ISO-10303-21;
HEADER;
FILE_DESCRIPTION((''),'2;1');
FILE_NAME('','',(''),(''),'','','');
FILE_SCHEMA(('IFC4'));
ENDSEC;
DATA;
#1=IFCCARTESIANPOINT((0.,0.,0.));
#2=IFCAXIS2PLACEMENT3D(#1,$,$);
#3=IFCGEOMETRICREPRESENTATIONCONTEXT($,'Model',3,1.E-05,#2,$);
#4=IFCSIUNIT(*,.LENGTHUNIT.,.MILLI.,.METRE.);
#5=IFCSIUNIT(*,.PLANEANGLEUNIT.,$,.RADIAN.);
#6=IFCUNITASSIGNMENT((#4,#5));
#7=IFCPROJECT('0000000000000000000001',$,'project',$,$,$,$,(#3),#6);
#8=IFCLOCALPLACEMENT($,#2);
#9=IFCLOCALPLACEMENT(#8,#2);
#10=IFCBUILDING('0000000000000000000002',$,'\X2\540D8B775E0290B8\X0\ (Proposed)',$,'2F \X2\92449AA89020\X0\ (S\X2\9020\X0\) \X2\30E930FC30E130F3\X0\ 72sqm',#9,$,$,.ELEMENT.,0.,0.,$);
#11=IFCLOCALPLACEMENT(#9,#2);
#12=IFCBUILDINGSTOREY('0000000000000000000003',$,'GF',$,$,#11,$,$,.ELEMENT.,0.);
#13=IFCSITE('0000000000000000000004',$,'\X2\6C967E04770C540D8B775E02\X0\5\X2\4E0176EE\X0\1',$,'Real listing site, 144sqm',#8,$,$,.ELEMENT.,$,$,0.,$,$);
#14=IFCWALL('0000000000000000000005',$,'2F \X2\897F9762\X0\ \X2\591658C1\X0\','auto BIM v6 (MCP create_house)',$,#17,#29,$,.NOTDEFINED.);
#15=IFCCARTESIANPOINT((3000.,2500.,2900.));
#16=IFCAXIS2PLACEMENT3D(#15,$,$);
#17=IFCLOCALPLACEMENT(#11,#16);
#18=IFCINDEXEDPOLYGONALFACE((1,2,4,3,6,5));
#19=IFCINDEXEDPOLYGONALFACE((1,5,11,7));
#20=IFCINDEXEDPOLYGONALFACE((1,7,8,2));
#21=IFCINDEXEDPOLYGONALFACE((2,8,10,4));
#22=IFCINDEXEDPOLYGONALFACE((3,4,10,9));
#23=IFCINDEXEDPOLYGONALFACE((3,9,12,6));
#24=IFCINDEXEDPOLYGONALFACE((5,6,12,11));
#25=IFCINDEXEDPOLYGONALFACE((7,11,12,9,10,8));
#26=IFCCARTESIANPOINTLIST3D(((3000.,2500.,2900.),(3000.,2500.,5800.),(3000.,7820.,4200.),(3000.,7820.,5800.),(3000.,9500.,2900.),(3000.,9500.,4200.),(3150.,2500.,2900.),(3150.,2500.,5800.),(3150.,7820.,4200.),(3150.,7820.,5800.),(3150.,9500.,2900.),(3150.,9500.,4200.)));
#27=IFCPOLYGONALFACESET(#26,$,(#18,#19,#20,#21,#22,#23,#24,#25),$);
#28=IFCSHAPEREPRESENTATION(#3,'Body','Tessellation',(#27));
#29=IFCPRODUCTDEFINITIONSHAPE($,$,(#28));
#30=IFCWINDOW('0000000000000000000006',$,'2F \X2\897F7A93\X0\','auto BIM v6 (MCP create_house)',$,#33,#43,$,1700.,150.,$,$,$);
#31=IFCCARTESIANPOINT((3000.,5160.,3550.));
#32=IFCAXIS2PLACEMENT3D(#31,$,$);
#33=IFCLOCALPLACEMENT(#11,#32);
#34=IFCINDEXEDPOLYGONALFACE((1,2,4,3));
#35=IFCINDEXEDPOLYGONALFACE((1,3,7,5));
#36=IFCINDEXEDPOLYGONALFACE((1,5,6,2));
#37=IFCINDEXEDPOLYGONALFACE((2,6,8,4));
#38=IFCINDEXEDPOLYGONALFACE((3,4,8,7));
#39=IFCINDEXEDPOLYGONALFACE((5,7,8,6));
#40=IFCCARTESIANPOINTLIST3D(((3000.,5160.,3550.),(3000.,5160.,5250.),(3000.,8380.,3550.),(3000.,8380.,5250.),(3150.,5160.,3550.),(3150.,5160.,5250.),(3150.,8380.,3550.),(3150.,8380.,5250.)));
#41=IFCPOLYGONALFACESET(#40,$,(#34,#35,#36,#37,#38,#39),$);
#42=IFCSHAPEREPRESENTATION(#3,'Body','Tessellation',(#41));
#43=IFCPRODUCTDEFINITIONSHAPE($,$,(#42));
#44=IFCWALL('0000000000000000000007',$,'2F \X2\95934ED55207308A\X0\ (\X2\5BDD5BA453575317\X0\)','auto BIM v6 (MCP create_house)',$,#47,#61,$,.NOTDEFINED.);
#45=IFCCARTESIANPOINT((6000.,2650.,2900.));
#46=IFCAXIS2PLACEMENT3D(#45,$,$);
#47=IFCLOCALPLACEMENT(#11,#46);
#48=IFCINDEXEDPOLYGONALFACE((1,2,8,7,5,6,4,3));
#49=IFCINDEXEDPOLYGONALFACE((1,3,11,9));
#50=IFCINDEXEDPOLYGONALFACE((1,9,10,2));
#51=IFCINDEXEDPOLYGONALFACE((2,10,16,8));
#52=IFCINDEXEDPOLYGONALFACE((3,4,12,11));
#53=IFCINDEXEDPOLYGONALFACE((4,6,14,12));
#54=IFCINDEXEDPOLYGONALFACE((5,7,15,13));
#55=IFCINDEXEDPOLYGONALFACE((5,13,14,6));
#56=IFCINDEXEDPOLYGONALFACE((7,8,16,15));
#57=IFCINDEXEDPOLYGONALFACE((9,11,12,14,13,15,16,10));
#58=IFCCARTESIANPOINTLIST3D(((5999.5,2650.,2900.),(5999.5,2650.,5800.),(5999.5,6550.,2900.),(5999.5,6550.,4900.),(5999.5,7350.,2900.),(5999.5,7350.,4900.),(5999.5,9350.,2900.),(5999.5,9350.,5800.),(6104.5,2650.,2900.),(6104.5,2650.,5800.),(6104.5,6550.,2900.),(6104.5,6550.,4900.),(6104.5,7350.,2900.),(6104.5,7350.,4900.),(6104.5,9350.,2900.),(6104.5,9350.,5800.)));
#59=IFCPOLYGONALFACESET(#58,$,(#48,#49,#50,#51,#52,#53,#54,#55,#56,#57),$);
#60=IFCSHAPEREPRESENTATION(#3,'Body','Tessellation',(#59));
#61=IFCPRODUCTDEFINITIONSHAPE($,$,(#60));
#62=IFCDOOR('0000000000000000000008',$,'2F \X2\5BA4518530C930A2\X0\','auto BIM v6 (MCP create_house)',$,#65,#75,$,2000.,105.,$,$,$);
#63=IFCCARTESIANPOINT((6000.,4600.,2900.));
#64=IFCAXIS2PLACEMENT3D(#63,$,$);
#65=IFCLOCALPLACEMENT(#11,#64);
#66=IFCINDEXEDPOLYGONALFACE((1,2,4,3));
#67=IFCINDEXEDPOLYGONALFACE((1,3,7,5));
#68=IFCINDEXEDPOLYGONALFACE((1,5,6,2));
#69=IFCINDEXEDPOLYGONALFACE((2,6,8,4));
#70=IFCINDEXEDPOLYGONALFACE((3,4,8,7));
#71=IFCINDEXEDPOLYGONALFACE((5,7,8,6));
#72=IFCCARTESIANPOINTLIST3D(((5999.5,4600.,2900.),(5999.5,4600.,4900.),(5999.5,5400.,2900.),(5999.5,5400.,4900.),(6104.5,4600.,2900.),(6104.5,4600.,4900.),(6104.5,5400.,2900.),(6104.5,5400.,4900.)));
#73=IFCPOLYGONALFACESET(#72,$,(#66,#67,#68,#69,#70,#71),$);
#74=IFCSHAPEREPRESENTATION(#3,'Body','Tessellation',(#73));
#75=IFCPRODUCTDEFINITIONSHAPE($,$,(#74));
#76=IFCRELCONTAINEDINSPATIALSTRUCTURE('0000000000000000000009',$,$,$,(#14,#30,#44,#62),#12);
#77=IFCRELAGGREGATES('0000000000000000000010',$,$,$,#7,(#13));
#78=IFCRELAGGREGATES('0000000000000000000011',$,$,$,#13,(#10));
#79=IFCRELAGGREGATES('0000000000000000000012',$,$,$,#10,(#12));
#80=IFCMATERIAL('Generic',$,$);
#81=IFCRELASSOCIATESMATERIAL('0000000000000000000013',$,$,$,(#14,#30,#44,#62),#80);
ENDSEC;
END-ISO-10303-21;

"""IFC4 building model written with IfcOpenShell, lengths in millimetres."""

from ifc_helpers import new_model, si_unit, frame, frame_2d, origin, place, context, project, spatial, rectangle, extrude, material, element, fill, save


model = new_model("IFC4")

# Units and contexts
model_context = context("Model", 3, precision=1e-05, world=origin())
ifc_project = project(units=[si_unit("LENGTHUNIT", "METRE", prefix="MILLI"), si_unit("PLANEANGLEUNIT", "RADIAN")], contexts=[model_context])

# Site, building, storey
site_placement = place(None, origin())
site = spatial("IfcSite", under=ifc_project, at=site_placement, Name="沖縄県名護市5丁目1", ObjectType="Real listing site, 144sqm", CompositionType="ELEMENT", RefElevation=0.0)
building_placement = place(site_placement, origin())
building = spatial("IfcBuilding", under=site, at=building_placement, Name="名護市邸 (Proposed)", ObjectType="2F 鉄骨造 (S造) ラーメン 72sqm", CompositionType="ELEMENT", ElevationOfRefHeight=0.0, ElevationOfTerrain=0.0)
storey_placement = place(building_placement, origin())
storey = spatial("IfcBuildingStorey", under=building, at=storey_placement, Name="GF", CompositionType="ELEMENT", Elevation=0.0)

# Shared definitions
ifc_material = material(Name="Generic")

# Wall, opening, window
wall_1_placement = place(storey_placement, frame((3000.0, 2500.0, 2900.0)))
wall_1 = element("IfcWall", 1, at=wall_1_placement, inside=storey, material=ifc_material, Name="2F 西面 外壁", Description="auto BIM v6 (MCP create_house)", PredefinedType="NOTDEFINED", context=model_context, shape_type="SweptSolid", body=[
    extrude(rectangle(XDim=150.0, YDim=7000.0, at=frame_2d((75.0, 3500.0))), frame((3000.0, 2500.0, 2900.0)), (0.0, 0.0, 1.0), 2900.0),
])
opening_1_placement = place(storey_placement, frame((3000.0, 5160.0, 3550.0)))
opening_1 = element("IfcOpeningElement", 2, at=opening_1_placement, cuts=wall_1, PredefinedType="NOTDEFINED", context=model_context, shape_type="SweptSolid", body=[
    extrude(rectangle(XDim=150.0, YDim=3220.0, at=frame_2d((75.0, 1610.0))), frame((3000.0, 5160.0, 3550.0)), (0.0, 0.0, 1.0), 1700.0),
])
window_1_placement = place(storey_placement, frame((3000.0, 5160.0, 3550.0)))
window_1 = element("IfcWindow", 3, at=window_1_placement, inside=storey, material=ifc_material, Name="2F 西窓", Description="auto BIM v6 (MCP create_house)", OverallHeight=1700.0, OverallWidth=150.0, context=model_context, shape_type="SweptSolid", body=[
    extrude(rectangle(XDim=150.0, YDim=3220.0, at=frame_2d((75.0, 1610.0))), frame((3000.0, 5160.0, 3550.0)), (0.0, 0.0, 1.0), 1700.0),
])
fill(opening_1, window_1)

# Wall, opening, door
wall_2_placement = place(storey_placement, frame((6000.0, 2650.0, 2900.0)))
wall_2 = element("IfcWall", 4, at=wall_2_placement, inside=storey, material=ifc_material, Name="2F 間仕切り (寝室南北)", Description="auto BIM v6 (MCP create_house)", PredefinedType="NOTDEFINED", context=model_context, shape_type="SweptSolid", body=[
    extrude(rectangle(XDim=105.0, YDim=6700.0, at=frame_2d((52.0, 3350.0))), frame((6000.0, 2650.0, 2900.0)), (0.0, 0.0, 1.0), 2900.0),
])
opening_2_placement = place(storey_placement, frame((6000.0, 4600.0, 2900.0)))
opening_2 = element("IfcOpeningElement", 5, at=opening_2_placement, cuts=wall_2, PredefinedType="NOTDEFINED", context=model_context, shape_type="SweptSolid", body=[
    extrude(rectangle(XDim=105.0, YDim=800.0, at=frame_2d((52.0, 400.0))), frame((6000.0, 4600.0, 2900.0)), (0.0, 0.0, 1.0), 2000.0),
])
door_placement = place(storey_placement, frame((6000.0, 4600.0, 2900.0)))
door = element("IfcDoor", 6, at=door_placement, inside=storey, material=ifc_material, Name="2F 室内ドア", Description="auto BIM v6 (MCP create_house)", OverallHeight=2000.0, OverallWidth=105.0, context=model_context, shape_type="SweptSolid", body=[
    extrude(rectangle(XDim=105.0, YDim=800.0, at=frame_2d((52.0, 400.0))), frame((6000.0, 4600.0, 2900.0)), (0.0, 0.0, 1.0), 2000.0),
])
fill(opening_2, door)

save(model, "model.ifc")
